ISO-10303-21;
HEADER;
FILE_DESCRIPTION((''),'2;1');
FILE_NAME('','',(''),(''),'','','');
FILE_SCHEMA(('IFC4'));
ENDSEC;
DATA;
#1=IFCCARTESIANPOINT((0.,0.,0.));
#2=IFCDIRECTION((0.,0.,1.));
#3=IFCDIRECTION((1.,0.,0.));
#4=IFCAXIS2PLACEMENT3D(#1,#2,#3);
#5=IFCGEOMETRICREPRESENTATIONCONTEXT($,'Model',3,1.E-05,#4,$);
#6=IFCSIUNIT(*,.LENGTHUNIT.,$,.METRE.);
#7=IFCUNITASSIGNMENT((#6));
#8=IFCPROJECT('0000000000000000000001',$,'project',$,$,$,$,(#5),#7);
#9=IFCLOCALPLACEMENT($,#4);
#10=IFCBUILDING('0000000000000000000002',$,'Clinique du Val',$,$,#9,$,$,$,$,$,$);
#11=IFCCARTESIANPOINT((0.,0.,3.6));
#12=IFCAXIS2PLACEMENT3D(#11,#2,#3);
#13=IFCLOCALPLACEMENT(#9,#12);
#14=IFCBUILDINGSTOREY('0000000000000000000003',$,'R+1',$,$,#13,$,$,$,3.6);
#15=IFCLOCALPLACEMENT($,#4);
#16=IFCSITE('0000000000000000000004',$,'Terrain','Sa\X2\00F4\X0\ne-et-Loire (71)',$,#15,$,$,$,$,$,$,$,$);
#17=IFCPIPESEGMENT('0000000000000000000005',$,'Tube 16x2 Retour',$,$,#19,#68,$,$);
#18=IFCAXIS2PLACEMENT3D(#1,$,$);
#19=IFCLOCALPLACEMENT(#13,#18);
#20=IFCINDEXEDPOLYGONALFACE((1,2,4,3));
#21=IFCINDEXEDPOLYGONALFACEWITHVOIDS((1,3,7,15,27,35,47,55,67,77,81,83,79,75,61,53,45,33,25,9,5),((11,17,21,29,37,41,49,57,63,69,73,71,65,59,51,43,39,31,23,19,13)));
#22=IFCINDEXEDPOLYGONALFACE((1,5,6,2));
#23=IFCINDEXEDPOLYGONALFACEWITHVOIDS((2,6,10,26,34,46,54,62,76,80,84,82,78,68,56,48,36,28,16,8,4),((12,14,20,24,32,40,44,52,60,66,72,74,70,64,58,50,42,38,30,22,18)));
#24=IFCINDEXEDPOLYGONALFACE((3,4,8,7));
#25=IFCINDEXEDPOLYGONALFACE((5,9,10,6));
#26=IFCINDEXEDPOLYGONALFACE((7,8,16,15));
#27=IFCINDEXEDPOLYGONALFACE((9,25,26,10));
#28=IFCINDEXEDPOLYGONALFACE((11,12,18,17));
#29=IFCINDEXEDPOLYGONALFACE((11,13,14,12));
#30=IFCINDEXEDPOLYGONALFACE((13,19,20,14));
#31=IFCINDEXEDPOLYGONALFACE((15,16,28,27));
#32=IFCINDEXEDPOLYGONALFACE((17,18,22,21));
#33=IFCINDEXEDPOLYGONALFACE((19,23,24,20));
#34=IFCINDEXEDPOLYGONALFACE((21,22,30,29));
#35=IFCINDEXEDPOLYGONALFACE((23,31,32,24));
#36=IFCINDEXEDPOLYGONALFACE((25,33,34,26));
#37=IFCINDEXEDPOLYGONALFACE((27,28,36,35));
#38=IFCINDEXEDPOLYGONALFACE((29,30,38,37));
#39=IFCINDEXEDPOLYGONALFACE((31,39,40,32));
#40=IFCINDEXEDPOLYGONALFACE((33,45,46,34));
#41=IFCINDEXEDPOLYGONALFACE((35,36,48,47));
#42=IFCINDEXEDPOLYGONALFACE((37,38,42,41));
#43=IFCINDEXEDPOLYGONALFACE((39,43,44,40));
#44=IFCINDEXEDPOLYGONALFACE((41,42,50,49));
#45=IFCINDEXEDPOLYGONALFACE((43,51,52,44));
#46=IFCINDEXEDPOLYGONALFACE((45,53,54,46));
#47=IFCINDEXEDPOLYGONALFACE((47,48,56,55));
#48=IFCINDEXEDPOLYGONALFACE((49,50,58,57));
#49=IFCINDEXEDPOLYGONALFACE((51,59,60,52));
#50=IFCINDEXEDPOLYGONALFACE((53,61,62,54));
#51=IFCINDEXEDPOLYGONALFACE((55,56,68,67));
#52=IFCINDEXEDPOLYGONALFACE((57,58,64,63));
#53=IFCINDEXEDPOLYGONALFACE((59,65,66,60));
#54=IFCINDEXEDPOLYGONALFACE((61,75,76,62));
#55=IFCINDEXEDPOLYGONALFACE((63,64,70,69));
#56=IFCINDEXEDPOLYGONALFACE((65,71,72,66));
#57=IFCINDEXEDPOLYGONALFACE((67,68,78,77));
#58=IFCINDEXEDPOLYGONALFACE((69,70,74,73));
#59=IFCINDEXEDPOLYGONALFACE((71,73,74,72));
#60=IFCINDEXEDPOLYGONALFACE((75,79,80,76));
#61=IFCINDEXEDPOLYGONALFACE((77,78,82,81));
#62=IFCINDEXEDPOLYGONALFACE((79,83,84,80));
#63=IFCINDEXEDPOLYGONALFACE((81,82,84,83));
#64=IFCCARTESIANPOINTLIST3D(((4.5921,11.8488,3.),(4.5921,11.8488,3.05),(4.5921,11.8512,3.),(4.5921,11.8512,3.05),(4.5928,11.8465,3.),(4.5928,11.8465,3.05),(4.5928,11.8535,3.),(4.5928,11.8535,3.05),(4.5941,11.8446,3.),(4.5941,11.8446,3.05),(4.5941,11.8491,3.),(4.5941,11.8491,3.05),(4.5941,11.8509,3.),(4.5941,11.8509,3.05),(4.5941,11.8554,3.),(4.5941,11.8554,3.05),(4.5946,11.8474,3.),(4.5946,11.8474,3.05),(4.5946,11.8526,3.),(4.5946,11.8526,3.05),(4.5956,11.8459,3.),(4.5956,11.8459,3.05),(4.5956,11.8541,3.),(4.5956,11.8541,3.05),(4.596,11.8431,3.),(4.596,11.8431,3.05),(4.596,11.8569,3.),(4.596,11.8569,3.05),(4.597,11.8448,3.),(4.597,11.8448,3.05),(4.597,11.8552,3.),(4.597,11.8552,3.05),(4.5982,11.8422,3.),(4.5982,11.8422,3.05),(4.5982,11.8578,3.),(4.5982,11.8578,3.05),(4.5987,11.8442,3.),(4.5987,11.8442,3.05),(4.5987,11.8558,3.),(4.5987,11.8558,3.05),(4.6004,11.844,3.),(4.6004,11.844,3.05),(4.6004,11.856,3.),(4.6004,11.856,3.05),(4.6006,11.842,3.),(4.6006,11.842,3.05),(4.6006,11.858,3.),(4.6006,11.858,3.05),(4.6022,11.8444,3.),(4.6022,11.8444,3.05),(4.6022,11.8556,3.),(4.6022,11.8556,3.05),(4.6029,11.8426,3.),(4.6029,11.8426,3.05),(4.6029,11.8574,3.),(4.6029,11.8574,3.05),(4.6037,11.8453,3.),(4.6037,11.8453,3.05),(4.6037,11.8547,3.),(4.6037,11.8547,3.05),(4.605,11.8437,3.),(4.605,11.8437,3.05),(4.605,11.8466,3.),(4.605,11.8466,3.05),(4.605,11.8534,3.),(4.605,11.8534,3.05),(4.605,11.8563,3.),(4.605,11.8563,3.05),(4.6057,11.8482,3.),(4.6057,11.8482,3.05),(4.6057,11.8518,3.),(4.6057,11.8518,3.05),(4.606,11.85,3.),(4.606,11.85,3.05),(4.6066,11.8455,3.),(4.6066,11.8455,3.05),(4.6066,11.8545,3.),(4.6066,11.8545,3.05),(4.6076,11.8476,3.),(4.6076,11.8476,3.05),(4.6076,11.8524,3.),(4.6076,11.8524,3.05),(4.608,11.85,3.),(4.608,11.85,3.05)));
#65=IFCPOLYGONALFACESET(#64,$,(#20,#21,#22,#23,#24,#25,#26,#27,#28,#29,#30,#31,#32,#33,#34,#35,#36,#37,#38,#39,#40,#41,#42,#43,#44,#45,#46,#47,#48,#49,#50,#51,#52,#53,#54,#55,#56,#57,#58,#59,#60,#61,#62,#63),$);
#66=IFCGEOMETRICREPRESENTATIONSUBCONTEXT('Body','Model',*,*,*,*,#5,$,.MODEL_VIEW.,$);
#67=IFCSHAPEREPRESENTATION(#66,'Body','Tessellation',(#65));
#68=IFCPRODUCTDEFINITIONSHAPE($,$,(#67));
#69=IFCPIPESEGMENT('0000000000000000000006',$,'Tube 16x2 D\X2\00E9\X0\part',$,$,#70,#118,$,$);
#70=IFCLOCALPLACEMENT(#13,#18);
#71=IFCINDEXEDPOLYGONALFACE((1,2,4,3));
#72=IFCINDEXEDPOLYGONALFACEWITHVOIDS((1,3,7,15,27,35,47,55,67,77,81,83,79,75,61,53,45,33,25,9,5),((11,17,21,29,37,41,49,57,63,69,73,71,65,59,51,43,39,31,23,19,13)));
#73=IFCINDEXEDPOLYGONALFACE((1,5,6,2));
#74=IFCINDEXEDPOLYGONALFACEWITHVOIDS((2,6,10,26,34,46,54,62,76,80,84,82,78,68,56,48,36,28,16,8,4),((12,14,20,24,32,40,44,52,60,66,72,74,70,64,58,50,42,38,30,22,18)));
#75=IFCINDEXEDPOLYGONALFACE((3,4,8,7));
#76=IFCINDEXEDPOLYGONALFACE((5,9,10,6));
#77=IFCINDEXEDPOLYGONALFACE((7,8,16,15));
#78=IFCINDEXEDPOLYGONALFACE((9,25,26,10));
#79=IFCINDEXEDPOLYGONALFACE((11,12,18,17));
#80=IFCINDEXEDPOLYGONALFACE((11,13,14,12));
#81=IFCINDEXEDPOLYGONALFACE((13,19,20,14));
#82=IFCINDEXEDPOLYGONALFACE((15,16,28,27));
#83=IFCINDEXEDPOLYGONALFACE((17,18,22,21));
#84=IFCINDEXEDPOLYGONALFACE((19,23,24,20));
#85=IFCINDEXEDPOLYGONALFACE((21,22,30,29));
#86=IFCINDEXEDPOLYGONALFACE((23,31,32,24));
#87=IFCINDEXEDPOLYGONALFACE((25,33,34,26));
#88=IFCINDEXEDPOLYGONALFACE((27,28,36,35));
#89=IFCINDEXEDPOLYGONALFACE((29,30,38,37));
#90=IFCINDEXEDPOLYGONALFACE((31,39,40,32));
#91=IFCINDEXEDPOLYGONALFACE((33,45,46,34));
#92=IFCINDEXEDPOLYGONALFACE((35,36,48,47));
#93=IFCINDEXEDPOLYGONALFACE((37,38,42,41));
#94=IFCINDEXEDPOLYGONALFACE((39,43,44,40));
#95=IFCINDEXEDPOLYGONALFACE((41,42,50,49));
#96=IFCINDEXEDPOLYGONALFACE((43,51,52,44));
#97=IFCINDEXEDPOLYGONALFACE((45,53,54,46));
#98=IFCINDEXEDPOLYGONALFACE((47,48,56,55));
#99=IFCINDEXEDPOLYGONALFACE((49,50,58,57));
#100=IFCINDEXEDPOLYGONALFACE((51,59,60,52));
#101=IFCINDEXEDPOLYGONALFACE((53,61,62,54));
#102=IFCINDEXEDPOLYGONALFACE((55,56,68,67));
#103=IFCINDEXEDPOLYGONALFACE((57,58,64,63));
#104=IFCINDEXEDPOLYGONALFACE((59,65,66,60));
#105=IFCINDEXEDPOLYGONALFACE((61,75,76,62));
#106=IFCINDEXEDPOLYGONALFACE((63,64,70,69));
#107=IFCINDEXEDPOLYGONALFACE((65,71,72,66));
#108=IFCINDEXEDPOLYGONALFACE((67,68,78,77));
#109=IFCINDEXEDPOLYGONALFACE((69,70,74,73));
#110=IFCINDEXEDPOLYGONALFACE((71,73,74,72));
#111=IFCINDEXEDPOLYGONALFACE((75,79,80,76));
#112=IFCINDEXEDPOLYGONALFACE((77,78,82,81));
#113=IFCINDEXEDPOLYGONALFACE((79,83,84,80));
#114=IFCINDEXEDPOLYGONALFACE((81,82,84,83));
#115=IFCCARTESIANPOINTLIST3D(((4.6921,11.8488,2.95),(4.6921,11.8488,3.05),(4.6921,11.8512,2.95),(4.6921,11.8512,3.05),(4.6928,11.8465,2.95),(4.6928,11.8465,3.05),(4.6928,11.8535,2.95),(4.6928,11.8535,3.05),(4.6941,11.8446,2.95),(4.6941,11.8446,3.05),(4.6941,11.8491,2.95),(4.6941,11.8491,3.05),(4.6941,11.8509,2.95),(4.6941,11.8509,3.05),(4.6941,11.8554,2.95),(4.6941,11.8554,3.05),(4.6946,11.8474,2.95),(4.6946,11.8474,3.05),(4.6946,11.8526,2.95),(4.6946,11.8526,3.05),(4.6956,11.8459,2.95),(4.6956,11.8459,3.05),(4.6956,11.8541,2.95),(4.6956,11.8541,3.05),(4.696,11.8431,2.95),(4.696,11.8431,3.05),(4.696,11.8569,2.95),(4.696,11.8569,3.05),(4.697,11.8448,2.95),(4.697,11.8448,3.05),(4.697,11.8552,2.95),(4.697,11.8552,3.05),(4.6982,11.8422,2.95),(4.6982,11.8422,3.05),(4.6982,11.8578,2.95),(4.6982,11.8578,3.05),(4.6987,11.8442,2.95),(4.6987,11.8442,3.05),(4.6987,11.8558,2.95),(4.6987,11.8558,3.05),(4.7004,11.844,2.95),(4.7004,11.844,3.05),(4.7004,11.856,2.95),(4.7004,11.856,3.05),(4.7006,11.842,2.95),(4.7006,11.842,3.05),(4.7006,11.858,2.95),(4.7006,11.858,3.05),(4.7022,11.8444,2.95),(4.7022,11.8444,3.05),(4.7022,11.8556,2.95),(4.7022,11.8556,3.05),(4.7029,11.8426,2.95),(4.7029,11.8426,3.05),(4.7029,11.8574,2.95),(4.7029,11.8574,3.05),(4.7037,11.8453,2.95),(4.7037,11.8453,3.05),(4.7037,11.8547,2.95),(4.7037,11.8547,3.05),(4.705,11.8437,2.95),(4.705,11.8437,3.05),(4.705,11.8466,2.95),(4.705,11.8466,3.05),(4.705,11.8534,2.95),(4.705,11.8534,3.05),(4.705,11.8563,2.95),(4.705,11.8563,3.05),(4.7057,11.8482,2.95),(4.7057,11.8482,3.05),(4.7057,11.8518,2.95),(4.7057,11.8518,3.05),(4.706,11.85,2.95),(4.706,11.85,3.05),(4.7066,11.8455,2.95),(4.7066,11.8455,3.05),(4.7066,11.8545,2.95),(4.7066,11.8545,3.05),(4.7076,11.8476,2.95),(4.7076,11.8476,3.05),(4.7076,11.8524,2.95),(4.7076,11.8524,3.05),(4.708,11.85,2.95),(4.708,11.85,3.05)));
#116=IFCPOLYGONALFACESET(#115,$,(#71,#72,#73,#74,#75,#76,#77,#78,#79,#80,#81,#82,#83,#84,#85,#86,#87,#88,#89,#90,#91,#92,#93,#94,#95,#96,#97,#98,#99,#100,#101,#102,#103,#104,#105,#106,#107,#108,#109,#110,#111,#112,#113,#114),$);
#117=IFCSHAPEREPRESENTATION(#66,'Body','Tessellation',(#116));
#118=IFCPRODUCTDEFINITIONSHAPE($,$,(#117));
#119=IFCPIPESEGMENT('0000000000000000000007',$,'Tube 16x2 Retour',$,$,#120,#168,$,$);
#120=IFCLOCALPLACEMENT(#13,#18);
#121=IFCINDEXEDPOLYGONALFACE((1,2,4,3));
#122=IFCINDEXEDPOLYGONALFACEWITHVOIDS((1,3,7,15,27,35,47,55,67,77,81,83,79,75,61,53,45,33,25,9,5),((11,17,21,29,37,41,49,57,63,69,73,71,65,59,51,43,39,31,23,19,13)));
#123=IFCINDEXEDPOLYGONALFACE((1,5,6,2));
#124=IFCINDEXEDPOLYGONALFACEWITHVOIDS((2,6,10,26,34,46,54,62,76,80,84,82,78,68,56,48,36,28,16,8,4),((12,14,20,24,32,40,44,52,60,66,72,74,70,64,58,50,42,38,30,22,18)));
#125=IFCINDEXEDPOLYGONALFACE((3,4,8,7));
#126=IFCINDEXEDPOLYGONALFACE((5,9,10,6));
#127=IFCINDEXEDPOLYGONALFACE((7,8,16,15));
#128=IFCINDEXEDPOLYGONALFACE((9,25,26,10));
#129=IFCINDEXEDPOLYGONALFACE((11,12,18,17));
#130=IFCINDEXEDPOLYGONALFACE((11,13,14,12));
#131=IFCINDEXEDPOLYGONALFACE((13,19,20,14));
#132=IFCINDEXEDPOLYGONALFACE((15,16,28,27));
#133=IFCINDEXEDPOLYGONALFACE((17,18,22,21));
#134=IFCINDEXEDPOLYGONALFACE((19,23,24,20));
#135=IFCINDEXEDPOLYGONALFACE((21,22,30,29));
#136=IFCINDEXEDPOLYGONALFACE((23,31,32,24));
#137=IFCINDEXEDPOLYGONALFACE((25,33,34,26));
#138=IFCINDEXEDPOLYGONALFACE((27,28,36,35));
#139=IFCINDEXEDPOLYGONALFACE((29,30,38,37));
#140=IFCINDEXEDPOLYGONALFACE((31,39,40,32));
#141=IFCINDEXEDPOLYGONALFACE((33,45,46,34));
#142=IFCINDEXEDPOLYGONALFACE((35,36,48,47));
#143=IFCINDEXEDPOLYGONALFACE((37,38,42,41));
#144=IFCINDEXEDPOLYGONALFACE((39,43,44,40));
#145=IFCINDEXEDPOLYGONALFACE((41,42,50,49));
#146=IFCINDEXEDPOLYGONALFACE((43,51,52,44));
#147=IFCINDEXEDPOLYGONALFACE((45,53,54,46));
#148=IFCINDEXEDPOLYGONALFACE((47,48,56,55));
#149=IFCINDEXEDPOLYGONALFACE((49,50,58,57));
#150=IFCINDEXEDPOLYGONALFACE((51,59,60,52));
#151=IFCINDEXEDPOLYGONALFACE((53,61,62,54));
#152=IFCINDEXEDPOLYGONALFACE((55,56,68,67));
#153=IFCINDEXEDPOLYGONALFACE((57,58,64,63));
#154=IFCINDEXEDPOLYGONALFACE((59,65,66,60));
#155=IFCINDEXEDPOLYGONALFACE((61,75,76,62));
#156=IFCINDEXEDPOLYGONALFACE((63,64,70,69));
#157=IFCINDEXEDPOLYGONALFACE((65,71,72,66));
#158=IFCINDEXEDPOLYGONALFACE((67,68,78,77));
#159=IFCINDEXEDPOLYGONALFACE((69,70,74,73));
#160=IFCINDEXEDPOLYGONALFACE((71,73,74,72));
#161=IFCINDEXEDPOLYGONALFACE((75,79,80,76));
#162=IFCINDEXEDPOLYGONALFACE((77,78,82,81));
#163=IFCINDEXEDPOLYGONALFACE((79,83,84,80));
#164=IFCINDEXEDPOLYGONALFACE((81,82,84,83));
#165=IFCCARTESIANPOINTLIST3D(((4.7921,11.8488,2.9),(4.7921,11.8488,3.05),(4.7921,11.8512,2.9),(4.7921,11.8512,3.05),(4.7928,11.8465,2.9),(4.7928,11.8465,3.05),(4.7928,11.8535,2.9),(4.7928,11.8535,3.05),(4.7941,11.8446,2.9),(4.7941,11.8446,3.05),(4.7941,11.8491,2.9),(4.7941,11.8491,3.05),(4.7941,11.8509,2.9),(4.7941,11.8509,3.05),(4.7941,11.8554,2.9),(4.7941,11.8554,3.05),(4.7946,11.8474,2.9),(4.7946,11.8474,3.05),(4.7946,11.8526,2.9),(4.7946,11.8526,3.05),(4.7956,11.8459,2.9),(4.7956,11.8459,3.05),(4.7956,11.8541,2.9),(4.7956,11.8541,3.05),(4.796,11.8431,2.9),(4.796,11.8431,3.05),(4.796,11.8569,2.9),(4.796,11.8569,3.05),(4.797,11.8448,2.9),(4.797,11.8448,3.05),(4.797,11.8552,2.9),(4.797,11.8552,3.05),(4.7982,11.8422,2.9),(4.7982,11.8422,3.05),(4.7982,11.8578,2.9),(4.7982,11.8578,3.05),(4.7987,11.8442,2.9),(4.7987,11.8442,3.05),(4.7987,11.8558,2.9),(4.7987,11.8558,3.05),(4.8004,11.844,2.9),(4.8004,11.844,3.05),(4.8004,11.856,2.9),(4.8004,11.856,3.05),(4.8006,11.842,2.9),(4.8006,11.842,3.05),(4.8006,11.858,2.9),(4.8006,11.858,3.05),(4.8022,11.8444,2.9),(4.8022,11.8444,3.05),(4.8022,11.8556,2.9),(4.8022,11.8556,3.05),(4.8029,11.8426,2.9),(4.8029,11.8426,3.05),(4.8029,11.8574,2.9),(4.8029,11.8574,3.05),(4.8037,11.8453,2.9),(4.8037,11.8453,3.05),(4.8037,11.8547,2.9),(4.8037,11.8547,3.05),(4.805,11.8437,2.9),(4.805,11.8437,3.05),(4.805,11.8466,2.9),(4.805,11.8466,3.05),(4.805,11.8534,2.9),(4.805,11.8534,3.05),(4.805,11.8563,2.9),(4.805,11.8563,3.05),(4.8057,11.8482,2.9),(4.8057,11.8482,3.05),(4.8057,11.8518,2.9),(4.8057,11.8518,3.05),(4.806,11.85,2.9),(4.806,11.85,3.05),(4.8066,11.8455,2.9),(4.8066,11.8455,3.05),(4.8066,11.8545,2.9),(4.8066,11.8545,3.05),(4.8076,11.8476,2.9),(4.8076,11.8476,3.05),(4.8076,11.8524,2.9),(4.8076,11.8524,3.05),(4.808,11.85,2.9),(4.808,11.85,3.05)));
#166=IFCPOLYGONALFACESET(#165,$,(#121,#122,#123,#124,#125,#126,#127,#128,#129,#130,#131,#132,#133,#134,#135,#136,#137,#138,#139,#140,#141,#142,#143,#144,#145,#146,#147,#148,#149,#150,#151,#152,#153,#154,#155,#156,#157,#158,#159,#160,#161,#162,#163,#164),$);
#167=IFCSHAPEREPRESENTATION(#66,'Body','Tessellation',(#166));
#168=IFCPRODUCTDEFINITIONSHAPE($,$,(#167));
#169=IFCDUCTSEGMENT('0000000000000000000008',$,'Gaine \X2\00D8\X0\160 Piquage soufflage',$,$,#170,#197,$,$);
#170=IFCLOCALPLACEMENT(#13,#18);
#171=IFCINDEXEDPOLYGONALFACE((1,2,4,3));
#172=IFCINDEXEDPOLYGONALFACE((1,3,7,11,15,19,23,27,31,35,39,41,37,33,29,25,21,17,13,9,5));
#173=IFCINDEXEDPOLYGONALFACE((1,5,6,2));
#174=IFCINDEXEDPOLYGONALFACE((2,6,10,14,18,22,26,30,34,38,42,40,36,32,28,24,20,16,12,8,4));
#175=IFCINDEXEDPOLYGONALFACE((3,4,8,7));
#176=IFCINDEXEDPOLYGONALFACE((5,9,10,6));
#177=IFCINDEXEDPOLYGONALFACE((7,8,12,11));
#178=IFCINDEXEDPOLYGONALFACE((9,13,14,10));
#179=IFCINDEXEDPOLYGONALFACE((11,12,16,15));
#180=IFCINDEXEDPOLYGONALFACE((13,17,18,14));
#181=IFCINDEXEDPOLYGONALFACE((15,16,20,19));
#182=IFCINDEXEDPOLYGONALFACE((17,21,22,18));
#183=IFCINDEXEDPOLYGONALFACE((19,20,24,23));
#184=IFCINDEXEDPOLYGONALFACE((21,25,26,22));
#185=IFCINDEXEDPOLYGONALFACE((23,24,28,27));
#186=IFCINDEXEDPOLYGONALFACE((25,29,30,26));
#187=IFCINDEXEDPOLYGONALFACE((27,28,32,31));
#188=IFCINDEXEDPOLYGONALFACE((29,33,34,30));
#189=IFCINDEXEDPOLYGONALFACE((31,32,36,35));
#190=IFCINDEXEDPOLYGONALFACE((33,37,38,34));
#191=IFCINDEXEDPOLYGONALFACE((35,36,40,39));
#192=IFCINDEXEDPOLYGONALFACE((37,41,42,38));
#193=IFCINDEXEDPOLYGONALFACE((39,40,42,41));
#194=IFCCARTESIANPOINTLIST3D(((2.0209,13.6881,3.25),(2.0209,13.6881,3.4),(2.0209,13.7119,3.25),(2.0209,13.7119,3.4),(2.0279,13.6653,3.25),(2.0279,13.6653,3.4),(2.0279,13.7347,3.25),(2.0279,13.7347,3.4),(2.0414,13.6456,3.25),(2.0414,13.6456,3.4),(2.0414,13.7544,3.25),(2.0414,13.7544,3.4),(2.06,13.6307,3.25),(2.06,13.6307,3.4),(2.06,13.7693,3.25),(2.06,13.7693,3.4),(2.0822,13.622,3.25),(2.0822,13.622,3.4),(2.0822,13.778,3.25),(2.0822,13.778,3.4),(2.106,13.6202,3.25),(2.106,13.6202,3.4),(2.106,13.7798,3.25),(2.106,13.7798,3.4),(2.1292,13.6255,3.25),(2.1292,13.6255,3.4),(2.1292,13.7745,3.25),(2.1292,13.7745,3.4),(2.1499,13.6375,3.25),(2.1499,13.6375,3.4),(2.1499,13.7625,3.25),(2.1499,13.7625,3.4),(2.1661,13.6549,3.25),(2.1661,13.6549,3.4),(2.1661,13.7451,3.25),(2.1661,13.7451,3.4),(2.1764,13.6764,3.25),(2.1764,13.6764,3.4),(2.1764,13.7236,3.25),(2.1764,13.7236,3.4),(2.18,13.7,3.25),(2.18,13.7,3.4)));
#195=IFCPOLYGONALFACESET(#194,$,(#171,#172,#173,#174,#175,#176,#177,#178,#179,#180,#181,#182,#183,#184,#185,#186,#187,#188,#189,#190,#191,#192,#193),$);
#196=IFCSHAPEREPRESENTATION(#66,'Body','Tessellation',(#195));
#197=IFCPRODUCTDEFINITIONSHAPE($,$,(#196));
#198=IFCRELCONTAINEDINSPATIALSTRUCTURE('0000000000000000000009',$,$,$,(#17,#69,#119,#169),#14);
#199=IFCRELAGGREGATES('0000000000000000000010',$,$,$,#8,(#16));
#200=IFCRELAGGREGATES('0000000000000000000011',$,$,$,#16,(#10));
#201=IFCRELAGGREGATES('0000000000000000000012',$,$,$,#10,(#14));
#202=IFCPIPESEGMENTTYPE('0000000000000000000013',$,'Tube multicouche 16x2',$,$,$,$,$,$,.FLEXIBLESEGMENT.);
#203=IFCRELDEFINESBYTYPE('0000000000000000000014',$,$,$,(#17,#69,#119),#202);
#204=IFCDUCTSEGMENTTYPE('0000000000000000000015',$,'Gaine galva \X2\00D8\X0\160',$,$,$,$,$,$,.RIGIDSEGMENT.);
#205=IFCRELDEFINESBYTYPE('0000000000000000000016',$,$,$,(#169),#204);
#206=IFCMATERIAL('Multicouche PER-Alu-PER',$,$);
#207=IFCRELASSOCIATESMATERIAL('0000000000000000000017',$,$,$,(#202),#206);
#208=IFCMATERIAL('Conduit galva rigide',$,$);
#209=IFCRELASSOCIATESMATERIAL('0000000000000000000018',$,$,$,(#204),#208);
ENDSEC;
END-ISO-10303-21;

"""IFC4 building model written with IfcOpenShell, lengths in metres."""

from ifc_helpers import new_model, si_unit, frame, origin_with_axes, place, context, subcontext, project, spatial, circle, hollow_circle, extrude, material, type_object, element, save


model = new_model("IFC4")

# Units and contexts
model_context = context("Model", 3, precision=1e-05, world=origin_with_axes())
body_context = subcontext(model_context, "Body", "Model", "MODEL_VIEW")
ifc_project = project(units=[si_unit("LENGTHUNIT", "METRE")], contexts=[model_context])

# Site, building, storey
site_placement = place(None, origin_with_axes())
site = spatial("IfcSite", under=ifc_project, at=site_placement, Name="Terrain", Description="Saône-et-Loire (71)")
building_placement = place(None, origin_with_axes())
building = spatial("IfcBuilding", under=site, at=building_placement, Name="Clinique du Val")
storey_placement = place(building_placement, frame((0.0, 0.0, 3.6), z_axis=(0.0, 0.0, 1.0), x_axis=(1.0, 0.0, 0.0)))
storey = spatial("IfcBuildingStorey", under=building, at=storey_placement, Name="R+1", Elevation=3.6)

# Pipe segments
ifc_material_1 = material(Name="Multicouche PER-Alu-PER")
pipe_segment_type = type_object("IfcPipeSegmentType", Name="Tube multicouche 16x2", PredefinedType="FLEXIBLESEGMENT", material=ifc_material_1)
pipe_segment_1_placement = place(storey_placement, frame((4.6, 11.85, 3.0), z_axis=(0.0, 0.0, 1.0), x_axis=(1.0, 0.0, 0.0)))
element("IfcPipeSegment", 1, at=pipe_segment_1_placement, inside=storey, type_object=pipe_segment_type, Name="Tube 16x2 Retour", context=body_context, shape_type="SweptSolid", body=[
    extrude(hollow_circle(Radius=0.008, WallThickness=0.002), origin_with_axes(), (0.0, 0.0, 1.0), 0.05),
])
pipe_segment_2_placement = place(storey_placement, frame((4.7, 11.85, 2.95), z_axis=(0.0, 0.0, 1.0), x_axis=(1.0, 0.0, 0.0)))
element("IfcPipeSegment", 2, at=pipe_segment_2_placement, inside=storey, type_object=pipe_segment_type, Name="Tube 16x2 Départ", context=body_context, shape_type="SweptSolid", body=[
    extrude(hollow_circle(Radius=0.008, WallThickness=0.002), origin_with_axes(), (0.0, 0.0, 1.0), 0.1),
])
pipe_segment_3_placement = place(storey_placement, frame((4.8, 11.85, 2.9), z_axis=(0.0, 0.0, 1.0), x_axis=(1.0, 0.0, 0.0)))
element("IfcPipeSegment", 3, at=pipe_segment_3_placement, inside=storey, type_object=pipe_segment_type, Name="Tube 16x2 Retour", context=body_context, shape_type="SweptSolid", body=[
    extrude(hollow_circle(Radius=0.008, WallThickness=0.002), origin_with_axes(), (0.0, 0.0, 1.0), 0.15),
])

# Duct segment
ifc_material_2 = material(Name="Conduit galva rigide")
duct_segment_type = type_object("IfcDuctSegmentType", Name="Gaine galva Ø160", PredefinedType="RIGIDSEGMENT", material=ifc_material_2)
duct_segment_1_placement = place(storey_placement, frame((2.1, 13.7, 3.4), z_axis=(0.0, 0.0, -1.0), x_axis=(1.0, 0.0, 0.0)))
element("IfcDuctSegment", 4, at=duct_segment_1_placement, inside=storey, type_object=duct_segment_type, Name="Gaine Ø160 Piquage soufflage", context=body_context, shape_type="SweptSolid", body=[
    extrude(circle(Radius=0.08), origin_with_axes(), (0.0, 0.0, 1.0), 0.15),
])

save(model, "model.ifc")
